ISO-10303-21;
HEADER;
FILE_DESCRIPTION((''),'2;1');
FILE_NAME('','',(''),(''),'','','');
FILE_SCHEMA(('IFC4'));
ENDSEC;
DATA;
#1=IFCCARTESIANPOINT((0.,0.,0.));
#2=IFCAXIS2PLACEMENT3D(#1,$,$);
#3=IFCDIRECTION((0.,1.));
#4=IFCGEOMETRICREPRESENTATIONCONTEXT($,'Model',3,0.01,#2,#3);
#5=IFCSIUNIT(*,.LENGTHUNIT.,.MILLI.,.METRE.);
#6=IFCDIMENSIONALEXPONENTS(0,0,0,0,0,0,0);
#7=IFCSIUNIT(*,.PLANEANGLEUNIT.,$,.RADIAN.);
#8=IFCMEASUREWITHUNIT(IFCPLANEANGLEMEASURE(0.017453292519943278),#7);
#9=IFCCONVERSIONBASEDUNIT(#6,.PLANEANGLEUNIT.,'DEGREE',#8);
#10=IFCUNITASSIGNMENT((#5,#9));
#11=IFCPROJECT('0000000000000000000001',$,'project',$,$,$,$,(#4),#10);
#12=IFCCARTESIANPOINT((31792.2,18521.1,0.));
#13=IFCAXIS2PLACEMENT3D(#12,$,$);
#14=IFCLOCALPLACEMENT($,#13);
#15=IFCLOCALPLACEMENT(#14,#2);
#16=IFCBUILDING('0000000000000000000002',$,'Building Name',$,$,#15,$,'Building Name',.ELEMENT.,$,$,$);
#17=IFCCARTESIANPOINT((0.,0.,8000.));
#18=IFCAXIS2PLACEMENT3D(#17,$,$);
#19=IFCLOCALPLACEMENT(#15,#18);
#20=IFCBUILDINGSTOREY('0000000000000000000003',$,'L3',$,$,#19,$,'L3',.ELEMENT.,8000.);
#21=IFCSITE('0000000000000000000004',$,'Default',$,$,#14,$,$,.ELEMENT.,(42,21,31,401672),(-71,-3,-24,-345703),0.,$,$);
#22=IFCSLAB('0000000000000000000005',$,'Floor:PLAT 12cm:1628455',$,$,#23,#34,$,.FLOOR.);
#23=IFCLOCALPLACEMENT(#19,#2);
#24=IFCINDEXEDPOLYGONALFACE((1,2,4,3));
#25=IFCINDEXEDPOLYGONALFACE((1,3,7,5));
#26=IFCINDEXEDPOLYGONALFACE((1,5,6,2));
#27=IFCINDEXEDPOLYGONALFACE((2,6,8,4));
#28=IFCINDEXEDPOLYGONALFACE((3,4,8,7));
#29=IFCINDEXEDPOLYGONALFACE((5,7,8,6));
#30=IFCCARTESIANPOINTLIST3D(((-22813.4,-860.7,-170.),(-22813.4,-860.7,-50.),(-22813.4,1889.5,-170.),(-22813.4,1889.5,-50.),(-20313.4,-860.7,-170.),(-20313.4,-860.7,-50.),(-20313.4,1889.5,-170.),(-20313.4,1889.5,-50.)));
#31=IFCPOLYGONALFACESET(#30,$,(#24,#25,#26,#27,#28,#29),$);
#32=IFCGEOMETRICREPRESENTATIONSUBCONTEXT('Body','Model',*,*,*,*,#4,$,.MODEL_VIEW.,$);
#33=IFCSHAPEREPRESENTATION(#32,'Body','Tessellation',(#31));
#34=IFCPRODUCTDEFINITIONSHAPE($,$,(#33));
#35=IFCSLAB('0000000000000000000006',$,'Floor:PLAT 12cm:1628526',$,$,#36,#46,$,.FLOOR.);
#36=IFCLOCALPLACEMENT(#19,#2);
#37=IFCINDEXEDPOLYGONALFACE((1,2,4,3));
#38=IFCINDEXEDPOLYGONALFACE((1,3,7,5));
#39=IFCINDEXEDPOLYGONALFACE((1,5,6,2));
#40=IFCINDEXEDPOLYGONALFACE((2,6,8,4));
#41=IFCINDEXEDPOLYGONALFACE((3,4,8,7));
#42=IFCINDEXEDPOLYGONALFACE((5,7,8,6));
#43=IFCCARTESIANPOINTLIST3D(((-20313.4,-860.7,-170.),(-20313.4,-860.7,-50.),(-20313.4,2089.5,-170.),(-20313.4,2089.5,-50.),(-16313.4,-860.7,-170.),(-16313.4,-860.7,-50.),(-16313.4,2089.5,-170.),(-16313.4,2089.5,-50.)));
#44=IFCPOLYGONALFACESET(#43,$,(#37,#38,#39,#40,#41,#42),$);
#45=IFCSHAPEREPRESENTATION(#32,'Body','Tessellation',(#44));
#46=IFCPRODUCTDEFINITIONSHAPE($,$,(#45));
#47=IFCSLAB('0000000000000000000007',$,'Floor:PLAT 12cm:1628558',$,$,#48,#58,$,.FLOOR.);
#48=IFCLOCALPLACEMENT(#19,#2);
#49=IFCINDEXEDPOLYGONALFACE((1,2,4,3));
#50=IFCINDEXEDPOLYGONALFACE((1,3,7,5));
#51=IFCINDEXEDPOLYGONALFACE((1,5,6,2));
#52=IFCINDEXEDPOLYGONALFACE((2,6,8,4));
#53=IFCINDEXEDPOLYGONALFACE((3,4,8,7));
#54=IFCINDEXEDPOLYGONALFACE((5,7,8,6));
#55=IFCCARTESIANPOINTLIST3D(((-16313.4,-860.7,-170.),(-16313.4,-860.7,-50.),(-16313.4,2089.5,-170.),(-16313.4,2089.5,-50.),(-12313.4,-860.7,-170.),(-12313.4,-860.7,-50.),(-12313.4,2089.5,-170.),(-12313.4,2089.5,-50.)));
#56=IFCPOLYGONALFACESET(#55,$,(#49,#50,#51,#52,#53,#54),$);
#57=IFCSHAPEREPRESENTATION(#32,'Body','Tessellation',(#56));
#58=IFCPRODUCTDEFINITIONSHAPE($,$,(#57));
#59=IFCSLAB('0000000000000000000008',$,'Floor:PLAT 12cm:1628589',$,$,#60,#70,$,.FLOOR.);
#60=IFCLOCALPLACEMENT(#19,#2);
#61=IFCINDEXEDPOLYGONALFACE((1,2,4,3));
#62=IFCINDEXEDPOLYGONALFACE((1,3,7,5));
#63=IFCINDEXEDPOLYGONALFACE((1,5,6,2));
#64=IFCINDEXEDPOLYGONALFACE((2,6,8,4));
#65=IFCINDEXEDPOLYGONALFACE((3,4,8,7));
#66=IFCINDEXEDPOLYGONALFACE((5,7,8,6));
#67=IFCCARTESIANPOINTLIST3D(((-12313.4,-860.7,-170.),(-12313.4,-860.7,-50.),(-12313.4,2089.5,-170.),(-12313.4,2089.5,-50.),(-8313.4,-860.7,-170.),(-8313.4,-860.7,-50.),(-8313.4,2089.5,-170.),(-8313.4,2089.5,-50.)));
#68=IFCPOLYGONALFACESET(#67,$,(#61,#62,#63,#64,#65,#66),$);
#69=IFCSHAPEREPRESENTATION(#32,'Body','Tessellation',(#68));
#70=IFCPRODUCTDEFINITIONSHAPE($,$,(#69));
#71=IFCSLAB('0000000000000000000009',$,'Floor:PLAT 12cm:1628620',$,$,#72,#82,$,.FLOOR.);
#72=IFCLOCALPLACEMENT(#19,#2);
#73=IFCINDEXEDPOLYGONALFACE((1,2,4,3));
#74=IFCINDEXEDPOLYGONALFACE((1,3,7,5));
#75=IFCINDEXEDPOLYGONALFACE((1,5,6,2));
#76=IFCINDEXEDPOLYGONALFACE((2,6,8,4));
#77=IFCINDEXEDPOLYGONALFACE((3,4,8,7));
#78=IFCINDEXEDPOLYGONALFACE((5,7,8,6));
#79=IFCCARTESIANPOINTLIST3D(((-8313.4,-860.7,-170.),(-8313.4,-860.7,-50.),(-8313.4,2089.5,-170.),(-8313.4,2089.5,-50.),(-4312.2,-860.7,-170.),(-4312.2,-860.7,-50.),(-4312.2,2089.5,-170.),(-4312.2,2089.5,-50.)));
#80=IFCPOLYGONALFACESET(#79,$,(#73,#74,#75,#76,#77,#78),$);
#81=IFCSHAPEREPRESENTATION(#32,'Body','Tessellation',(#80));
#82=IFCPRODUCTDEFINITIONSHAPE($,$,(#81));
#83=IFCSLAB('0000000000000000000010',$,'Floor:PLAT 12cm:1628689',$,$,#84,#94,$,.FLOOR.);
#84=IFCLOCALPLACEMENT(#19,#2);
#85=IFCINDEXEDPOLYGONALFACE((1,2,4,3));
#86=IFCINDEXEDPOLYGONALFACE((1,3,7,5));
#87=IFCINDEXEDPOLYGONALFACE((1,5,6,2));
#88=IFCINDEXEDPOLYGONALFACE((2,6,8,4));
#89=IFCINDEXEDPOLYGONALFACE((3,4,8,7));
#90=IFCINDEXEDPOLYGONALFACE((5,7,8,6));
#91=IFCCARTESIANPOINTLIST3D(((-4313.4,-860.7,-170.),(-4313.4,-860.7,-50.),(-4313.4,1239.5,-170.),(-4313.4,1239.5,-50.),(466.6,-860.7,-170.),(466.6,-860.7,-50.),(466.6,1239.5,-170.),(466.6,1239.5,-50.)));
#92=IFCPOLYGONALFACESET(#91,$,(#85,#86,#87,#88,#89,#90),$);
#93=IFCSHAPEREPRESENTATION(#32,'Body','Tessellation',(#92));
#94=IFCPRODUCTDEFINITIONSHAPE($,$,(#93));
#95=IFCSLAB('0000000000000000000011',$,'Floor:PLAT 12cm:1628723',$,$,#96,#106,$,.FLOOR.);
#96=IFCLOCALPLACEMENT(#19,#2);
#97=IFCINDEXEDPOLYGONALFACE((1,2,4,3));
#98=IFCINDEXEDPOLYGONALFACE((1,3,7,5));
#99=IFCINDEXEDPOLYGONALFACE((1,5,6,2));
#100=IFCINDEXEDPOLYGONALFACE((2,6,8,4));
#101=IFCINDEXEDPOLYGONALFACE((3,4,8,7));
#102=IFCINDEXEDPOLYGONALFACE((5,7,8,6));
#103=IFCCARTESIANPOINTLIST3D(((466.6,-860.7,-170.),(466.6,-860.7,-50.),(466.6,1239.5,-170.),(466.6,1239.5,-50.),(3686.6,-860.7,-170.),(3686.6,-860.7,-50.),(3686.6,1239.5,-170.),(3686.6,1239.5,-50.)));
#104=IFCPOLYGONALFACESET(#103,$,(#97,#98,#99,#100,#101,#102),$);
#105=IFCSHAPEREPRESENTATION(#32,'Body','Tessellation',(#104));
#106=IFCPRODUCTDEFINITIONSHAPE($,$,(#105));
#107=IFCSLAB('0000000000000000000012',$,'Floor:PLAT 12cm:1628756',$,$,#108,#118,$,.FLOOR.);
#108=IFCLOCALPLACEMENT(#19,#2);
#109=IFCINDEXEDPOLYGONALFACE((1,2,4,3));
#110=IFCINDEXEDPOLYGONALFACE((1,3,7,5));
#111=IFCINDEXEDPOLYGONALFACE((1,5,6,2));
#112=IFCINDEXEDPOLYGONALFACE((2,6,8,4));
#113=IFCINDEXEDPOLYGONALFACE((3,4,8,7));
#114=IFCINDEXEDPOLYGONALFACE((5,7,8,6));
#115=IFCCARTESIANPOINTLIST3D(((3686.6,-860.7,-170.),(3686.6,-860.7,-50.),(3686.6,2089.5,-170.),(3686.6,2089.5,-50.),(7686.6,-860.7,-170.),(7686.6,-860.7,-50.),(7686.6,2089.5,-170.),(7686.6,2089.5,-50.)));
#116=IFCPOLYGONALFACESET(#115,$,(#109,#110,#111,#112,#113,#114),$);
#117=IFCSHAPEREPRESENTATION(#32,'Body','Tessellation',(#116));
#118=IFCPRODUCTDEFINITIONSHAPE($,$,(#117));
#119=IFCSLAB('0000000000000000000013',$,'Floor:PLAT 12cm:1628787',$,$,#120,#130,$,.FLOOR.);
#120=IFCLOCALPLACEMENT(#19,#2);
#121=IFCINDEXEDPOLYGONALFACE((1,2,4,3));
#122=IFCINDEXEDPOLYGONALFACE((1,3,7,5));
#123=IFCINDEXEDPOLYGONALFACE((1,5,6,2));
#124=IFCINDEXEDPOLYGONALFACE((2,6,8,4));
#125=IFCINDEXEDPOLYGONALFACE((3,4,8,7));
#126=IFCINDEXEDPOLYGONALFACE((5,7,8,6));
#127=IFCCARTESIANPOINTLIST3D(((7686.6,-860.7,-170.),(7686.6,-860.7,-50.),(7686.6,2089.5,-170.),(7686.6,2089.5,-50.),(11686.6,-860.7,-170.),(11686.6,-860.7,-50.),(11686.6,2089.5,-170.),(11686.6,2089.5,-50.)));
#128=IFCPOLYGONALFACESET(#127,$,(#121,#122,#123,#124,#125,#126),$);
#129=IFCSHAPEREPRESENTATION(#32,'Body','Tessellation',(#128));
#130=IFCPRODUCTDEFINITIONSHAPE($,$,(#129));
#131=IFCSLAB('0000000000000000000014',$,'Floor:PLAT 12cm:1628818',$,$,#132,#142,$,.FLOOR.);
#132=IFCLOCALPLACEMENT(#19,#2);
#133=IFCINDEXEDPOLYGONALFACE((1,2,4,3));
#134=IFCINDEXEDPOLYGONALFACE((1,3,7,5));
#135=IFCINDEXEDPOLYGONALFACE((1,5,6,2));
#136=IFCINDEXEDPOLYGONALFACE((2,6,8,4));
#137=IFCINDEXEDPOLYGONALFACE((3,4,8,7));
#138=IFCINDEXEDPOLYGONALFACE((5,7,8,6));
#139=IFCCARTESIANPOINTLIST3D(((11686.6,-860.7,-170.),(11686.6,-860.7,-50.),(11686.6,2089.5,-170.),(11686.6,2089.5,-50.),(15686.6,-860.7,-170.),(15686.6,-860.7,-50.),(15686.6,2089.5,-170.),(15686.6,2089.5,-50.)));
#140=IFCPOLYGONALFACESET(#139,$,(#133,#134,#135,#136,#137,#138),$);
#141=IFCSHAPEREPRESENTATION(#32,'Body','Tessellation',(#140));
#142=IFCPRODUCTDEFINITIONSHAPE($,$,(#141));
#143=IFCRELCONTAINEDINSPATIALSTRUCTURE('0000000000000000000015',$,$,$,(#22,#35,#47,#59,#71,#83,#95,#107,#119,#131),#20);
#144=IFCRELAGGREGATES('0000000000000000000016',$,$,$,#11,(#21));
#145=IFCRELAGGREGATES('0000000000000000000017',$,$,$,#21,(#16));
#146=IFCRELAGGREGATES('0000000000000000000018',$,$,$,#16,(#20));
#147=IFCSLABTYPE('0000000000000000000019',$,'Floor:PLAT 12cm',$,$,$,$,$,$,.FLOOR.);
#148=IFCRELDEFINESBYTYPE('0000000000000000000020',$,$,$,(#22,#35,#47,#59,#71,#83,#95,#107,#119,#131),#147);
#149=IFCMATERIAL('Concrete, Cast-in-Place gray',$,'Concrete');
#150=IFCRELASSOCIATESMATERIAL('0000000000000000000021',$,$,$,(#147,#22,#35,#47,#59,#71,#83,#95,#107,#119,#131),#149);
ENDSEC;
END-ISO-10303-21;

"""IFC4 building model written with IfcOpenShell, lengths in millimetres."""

from ifc_helpers import new_model, entity, si_unit, converted_unit, direction, frame, origin, place, context, subcontext, project, spatial, indexed_curve, outline, extrude, material, type_object, element, save


model = new_model("IFC4")

# Units and contexts
model_context = context("Model", 3, precision=0.01, world=origin(), true_north=direction((0.0, 1.0)))
body_context = subcontext(model_context, "Body", "Model", "MODEL_VIEW")
ifc_project = project(units=[si_unit("LENGTHUNIT", "METRE", prefix="MILLI"), converted_unit("PLANEANGLEUNIT", "DEGREE", entity("IfcPlaneAngleMeasure", 0.017453292519943278), si_unit("PLANEANGLEUNIT", "RADIAN"), dimensions=[0, 0, 0, 0, 0, 0, 0])], contexts=[model_context])

# Site, building, storey
site_placement = place(None, frame((31792.2, 18521.1, 0.0)))
site = spatial("IfcSite", under=ifc_project, at=site_placement, Name="Default", CompositionType="ELEMENT", RefLatitude=(42, 21, 31, 401672), RefLongitude=(-71, -3, -24, -345703), RefElevation=0.0)
building_placement = place(site_placement, origin())
building = spatial("IfcBuilding", under=site, at=building_placement, Name="Building Name", LongName="Building Name", CompositionType="ELEMENT")
storey_placement = place(building_placement, frame((0.0, 0.0, 8000.0)))
storey = spatial("IfcBuildingStorey", under=building, at=storey_placement, Name="L3", LongName="L3", CompositionType="ELEMENT", Elevation=8000.0)

# Shared definitions
ifc_material = material(Name="Concrete, Cast-in-Place gray", Category="Concrete")

# Slabs
slab_type = type_object("IfcSlabType", Name="Floor:PLAT 12cm", PredefinedType="FLOOR", material=ifc_material)
slab_1_placement = place(storey_placement, origin())
element("IfcSlab", 1, at=slab_1_placement, inside=storey, type_object=slab_type, material=ifc_material, Name="Floor:PLAT 12cm:1628455", PredefinedType="FLOOR", context=body_context, shape_type="SweptSolid", body=[
    extrude(outline(indexed_curve([(-1375.1, -1250.0), (1375.1, -1250.0), (1375.1, 1250.0), (-1375.1, 1250.0), (-1375.1, -1250.0)], self_intersect=False)), frame((-21563.4, 514.4, -50.0), z_axis=(0.0, 0.0, -1.0), x_axis=(0.0, 1.0, 0.0)), (0.0, 0.0, 1.0), 120.0),
])
slab_2_placement = place(storey_placement, origin())
element("IfcSlab", 2, at=slab_2_placement, inside=storey, type_object=slab_type, material=ifc_material, Name="Floor:PLAT 12cm:1628526", PredefinedType="FLOOR", context=body_context, shape_type="SweptSolid", body=[
    extrude(outline(indexed_curve([(-1475.1, -2000.0), (1475.1, -2000.0), (1475.1, 2000.0), (-1475.1, 2000.0), (-1475.1, -2000.0)], self_intersect=False)), frame((-18313.4, 614.4, -50.0), z_axis=(0.0, 0.0, -1.0), x_axis=(0.0, 1.0, 0.0)), (0.0, 0.0, 1.0), 120.0),
])
slab_3_placement = place(storey_placement, origin())
element("IfcSlab", 3, at=slab_3_placement, inside=storey, type_object=slab_type, material=ifc_material, Name="Floor:PLAT 12cm:1628558", PredefinedType="FLOOR", context=body_context, shape_type="SweptSolid", body=[
    extrude(outline(indexed_curve([(-1475.1, -2000.0), (1475.1, -2000.0), (1475.1, 2000.0), (-1475.1, 2000.0), (-1475.1, -2000.0)], self_intersect=False)), frame((-14313.4, 614.4, -50.0), z_axis=(0.0, 0.0, -1.0), x_axis=(0.0, 1.0, 0.0)), (0.0, 0.0, 1.0), 120.0),
])
slab_4_placement = place(storey_placement, origin())
element("IfcSlab", 4, at=slab_4_placement, inside=storey, type_object=slab_type, material=ifc_material, Name="Floor:PLAT 12cm:1628589", PredefinedType="FLOOR", context=body_context, shape_type="SweptSolid", body=[
    extrude(outline(indexed_curve([(-1475.1, -2000.0), (1475.1, -2000.0), (1475.1, 2000.0), (-1475.1, 2000.0), (-1475.1, -2000.0)], self_intersect=False)), frame((-10313.4, 614.4, -50.0), z_axis=(0.0, 0.0, -1.0), x_axis=(0.0, 1.0, 0.0)), (0.0, 0.0, 1.0), 120.0),
])
slab_5_placement = place(storey_placement, origin())
element("IfcSlab", 5, at=slab_5_placement, inside=storey, type_object=slab_type, material=ifc_material, Name="Floor:PLAT 12cm:1628620", PredefinedType="FLOOR", context=body_context, shape_type="SweptSolid", body=[
    extrude(outline(indexed_curve([(-1475.1, -2000.6), (1475.1, -2000.6), (1475.1, 2000.6), (-1475.1, 2000.6), (-1475.1, -2000.6)], self_intersect=False)), frame((-6312.8, 614.4, -50.0), z_axis=(0.0, 0.0, -1.0), x_axis=(0.0, 1.0, 0.0)), (0.0, 0.0, 1.0), 120.0),
])
slab_6_placement = place(storey_placement, origin())
element("IfcSlab", 6, at=slab_6_placement, inside=storey, type_object=slab_type, material=ifc_material, Name="Floor:PLAT 12cm:1628689", PredefinedType="FLOOR", context=body_context, shape_type="SweptSolid", body=[
    extrude(outline(indexed_curve([(-1050.1, -2390.0), (1050.1, -2390.0), (1050.1, 2390.0), (-1050.1, 2390.0), (-1050.1, -2390.0)], self_intersect=False)), frame((-1923.4, 189.4, -50.0), z_axis=(0.0, 0.0, -1.0), x_axis=(0.0, 1.0, 0.0)), (0.0, 0.0, 1.0), 120.0),
])
slab_7_placement = place(storey_placement, origin())
element("IfcSlab", 7, at=slab_7_placement, inside=storey, type_object=slab_type, material=ifc_material, Name="Floor:PLAT 12cm:1628723", PredefinedType="FLOOR", context=body_context, shape_type="SweptSolid", body=[
    extrude(outline(indexed_curve([(-1050.1, -1610.0), (1050.1, -1610.0), (1050.1, 1610.0), (-1050.1, 1610.0), (-1050.1, -1610.0)], self_intersect=False)), frame((2076.6, 189.4, -50.0), z_axis=(0.0, 0.0, -1.0), x_axis=(0.0, 1.0, 0.0)), (0.0, 0.0, 1.0), 120.0),
])
slab_8_placement = place(storey_placement, origin())
element("IfcSlab", 8, at=slab_8_placement, inside=storey, type_object=slab_type, material=ifc_material, Name="Floor:PLAT 12cm:1628756", PredefinedType="FLOOR", context=body_context, shape_type="SweptSolid", body=[
    extrude(outline(indexed_curve([(-1475.1, -2000.0), (1475.1, -2000.0), (1475.1, 2000.0), (-1475.1, 2000.0), (-1475.1, -2000.0)], self_intersect=False)), frame((5686.6, 614.4, -50.0), z_axis=(0.0, 0.0, -1.0), x_axis=(0.0, 1.0, 0.0)), (0.0, 0.0, 1.0), 120.0),
])
slab_9_placement = place(storey_placement, origin())
element("IfcSlab", 9, at=slab_9_placement, inside=storey, type_object=slab_type, material=ifc_material, Name="Floor:PLAT 12cm:1628787", PredefinedType="FLOOR", context=body_context, shape_type="SweptSolid", body=[
    extrude(outline(indexed_curve([(-1475.1, -2000.0), (1475.1, -2000.0), (1475.1, 2000.0), (-1475.1, 2000.0), (-1475.1, -2000.0)], self_intersect=False)), frame((9686.6, 614.4, -50.0), z_axis=(0.0, 0.0, -1.0), x_axis=(0.0, 1.0, 0.0)), (0.0, 0.0, 1.0), 120.0),
])
slab_10_placement = place(storey_placement, origin())
element("IfcSlab", 10, at=slab_10_placement, inside=storey, type_object=slab_type, material=ifc_material, Name="Floor:PLAT 12cm:1628818", PredefinedType="FLOOR", context=body_context, shape_type="SweptSolid", body=[
    extrude(outline(indexed_curve([(-1475.1, -2000.0), (1475.1, -2000.0), (1475.1, 2000.0), (-1475.1, 2000.0), (-1475.1, -2000.0)], self_intersect=False)), frame((13686.6, 614.4, -50.0), z_axis=(0.0, 0.0, -1.0), x_axis=(0.0, 1.0, 0.0)), (0.0, 0.0, 1.0), 120.0),
])

save(model, "model.ifc")
